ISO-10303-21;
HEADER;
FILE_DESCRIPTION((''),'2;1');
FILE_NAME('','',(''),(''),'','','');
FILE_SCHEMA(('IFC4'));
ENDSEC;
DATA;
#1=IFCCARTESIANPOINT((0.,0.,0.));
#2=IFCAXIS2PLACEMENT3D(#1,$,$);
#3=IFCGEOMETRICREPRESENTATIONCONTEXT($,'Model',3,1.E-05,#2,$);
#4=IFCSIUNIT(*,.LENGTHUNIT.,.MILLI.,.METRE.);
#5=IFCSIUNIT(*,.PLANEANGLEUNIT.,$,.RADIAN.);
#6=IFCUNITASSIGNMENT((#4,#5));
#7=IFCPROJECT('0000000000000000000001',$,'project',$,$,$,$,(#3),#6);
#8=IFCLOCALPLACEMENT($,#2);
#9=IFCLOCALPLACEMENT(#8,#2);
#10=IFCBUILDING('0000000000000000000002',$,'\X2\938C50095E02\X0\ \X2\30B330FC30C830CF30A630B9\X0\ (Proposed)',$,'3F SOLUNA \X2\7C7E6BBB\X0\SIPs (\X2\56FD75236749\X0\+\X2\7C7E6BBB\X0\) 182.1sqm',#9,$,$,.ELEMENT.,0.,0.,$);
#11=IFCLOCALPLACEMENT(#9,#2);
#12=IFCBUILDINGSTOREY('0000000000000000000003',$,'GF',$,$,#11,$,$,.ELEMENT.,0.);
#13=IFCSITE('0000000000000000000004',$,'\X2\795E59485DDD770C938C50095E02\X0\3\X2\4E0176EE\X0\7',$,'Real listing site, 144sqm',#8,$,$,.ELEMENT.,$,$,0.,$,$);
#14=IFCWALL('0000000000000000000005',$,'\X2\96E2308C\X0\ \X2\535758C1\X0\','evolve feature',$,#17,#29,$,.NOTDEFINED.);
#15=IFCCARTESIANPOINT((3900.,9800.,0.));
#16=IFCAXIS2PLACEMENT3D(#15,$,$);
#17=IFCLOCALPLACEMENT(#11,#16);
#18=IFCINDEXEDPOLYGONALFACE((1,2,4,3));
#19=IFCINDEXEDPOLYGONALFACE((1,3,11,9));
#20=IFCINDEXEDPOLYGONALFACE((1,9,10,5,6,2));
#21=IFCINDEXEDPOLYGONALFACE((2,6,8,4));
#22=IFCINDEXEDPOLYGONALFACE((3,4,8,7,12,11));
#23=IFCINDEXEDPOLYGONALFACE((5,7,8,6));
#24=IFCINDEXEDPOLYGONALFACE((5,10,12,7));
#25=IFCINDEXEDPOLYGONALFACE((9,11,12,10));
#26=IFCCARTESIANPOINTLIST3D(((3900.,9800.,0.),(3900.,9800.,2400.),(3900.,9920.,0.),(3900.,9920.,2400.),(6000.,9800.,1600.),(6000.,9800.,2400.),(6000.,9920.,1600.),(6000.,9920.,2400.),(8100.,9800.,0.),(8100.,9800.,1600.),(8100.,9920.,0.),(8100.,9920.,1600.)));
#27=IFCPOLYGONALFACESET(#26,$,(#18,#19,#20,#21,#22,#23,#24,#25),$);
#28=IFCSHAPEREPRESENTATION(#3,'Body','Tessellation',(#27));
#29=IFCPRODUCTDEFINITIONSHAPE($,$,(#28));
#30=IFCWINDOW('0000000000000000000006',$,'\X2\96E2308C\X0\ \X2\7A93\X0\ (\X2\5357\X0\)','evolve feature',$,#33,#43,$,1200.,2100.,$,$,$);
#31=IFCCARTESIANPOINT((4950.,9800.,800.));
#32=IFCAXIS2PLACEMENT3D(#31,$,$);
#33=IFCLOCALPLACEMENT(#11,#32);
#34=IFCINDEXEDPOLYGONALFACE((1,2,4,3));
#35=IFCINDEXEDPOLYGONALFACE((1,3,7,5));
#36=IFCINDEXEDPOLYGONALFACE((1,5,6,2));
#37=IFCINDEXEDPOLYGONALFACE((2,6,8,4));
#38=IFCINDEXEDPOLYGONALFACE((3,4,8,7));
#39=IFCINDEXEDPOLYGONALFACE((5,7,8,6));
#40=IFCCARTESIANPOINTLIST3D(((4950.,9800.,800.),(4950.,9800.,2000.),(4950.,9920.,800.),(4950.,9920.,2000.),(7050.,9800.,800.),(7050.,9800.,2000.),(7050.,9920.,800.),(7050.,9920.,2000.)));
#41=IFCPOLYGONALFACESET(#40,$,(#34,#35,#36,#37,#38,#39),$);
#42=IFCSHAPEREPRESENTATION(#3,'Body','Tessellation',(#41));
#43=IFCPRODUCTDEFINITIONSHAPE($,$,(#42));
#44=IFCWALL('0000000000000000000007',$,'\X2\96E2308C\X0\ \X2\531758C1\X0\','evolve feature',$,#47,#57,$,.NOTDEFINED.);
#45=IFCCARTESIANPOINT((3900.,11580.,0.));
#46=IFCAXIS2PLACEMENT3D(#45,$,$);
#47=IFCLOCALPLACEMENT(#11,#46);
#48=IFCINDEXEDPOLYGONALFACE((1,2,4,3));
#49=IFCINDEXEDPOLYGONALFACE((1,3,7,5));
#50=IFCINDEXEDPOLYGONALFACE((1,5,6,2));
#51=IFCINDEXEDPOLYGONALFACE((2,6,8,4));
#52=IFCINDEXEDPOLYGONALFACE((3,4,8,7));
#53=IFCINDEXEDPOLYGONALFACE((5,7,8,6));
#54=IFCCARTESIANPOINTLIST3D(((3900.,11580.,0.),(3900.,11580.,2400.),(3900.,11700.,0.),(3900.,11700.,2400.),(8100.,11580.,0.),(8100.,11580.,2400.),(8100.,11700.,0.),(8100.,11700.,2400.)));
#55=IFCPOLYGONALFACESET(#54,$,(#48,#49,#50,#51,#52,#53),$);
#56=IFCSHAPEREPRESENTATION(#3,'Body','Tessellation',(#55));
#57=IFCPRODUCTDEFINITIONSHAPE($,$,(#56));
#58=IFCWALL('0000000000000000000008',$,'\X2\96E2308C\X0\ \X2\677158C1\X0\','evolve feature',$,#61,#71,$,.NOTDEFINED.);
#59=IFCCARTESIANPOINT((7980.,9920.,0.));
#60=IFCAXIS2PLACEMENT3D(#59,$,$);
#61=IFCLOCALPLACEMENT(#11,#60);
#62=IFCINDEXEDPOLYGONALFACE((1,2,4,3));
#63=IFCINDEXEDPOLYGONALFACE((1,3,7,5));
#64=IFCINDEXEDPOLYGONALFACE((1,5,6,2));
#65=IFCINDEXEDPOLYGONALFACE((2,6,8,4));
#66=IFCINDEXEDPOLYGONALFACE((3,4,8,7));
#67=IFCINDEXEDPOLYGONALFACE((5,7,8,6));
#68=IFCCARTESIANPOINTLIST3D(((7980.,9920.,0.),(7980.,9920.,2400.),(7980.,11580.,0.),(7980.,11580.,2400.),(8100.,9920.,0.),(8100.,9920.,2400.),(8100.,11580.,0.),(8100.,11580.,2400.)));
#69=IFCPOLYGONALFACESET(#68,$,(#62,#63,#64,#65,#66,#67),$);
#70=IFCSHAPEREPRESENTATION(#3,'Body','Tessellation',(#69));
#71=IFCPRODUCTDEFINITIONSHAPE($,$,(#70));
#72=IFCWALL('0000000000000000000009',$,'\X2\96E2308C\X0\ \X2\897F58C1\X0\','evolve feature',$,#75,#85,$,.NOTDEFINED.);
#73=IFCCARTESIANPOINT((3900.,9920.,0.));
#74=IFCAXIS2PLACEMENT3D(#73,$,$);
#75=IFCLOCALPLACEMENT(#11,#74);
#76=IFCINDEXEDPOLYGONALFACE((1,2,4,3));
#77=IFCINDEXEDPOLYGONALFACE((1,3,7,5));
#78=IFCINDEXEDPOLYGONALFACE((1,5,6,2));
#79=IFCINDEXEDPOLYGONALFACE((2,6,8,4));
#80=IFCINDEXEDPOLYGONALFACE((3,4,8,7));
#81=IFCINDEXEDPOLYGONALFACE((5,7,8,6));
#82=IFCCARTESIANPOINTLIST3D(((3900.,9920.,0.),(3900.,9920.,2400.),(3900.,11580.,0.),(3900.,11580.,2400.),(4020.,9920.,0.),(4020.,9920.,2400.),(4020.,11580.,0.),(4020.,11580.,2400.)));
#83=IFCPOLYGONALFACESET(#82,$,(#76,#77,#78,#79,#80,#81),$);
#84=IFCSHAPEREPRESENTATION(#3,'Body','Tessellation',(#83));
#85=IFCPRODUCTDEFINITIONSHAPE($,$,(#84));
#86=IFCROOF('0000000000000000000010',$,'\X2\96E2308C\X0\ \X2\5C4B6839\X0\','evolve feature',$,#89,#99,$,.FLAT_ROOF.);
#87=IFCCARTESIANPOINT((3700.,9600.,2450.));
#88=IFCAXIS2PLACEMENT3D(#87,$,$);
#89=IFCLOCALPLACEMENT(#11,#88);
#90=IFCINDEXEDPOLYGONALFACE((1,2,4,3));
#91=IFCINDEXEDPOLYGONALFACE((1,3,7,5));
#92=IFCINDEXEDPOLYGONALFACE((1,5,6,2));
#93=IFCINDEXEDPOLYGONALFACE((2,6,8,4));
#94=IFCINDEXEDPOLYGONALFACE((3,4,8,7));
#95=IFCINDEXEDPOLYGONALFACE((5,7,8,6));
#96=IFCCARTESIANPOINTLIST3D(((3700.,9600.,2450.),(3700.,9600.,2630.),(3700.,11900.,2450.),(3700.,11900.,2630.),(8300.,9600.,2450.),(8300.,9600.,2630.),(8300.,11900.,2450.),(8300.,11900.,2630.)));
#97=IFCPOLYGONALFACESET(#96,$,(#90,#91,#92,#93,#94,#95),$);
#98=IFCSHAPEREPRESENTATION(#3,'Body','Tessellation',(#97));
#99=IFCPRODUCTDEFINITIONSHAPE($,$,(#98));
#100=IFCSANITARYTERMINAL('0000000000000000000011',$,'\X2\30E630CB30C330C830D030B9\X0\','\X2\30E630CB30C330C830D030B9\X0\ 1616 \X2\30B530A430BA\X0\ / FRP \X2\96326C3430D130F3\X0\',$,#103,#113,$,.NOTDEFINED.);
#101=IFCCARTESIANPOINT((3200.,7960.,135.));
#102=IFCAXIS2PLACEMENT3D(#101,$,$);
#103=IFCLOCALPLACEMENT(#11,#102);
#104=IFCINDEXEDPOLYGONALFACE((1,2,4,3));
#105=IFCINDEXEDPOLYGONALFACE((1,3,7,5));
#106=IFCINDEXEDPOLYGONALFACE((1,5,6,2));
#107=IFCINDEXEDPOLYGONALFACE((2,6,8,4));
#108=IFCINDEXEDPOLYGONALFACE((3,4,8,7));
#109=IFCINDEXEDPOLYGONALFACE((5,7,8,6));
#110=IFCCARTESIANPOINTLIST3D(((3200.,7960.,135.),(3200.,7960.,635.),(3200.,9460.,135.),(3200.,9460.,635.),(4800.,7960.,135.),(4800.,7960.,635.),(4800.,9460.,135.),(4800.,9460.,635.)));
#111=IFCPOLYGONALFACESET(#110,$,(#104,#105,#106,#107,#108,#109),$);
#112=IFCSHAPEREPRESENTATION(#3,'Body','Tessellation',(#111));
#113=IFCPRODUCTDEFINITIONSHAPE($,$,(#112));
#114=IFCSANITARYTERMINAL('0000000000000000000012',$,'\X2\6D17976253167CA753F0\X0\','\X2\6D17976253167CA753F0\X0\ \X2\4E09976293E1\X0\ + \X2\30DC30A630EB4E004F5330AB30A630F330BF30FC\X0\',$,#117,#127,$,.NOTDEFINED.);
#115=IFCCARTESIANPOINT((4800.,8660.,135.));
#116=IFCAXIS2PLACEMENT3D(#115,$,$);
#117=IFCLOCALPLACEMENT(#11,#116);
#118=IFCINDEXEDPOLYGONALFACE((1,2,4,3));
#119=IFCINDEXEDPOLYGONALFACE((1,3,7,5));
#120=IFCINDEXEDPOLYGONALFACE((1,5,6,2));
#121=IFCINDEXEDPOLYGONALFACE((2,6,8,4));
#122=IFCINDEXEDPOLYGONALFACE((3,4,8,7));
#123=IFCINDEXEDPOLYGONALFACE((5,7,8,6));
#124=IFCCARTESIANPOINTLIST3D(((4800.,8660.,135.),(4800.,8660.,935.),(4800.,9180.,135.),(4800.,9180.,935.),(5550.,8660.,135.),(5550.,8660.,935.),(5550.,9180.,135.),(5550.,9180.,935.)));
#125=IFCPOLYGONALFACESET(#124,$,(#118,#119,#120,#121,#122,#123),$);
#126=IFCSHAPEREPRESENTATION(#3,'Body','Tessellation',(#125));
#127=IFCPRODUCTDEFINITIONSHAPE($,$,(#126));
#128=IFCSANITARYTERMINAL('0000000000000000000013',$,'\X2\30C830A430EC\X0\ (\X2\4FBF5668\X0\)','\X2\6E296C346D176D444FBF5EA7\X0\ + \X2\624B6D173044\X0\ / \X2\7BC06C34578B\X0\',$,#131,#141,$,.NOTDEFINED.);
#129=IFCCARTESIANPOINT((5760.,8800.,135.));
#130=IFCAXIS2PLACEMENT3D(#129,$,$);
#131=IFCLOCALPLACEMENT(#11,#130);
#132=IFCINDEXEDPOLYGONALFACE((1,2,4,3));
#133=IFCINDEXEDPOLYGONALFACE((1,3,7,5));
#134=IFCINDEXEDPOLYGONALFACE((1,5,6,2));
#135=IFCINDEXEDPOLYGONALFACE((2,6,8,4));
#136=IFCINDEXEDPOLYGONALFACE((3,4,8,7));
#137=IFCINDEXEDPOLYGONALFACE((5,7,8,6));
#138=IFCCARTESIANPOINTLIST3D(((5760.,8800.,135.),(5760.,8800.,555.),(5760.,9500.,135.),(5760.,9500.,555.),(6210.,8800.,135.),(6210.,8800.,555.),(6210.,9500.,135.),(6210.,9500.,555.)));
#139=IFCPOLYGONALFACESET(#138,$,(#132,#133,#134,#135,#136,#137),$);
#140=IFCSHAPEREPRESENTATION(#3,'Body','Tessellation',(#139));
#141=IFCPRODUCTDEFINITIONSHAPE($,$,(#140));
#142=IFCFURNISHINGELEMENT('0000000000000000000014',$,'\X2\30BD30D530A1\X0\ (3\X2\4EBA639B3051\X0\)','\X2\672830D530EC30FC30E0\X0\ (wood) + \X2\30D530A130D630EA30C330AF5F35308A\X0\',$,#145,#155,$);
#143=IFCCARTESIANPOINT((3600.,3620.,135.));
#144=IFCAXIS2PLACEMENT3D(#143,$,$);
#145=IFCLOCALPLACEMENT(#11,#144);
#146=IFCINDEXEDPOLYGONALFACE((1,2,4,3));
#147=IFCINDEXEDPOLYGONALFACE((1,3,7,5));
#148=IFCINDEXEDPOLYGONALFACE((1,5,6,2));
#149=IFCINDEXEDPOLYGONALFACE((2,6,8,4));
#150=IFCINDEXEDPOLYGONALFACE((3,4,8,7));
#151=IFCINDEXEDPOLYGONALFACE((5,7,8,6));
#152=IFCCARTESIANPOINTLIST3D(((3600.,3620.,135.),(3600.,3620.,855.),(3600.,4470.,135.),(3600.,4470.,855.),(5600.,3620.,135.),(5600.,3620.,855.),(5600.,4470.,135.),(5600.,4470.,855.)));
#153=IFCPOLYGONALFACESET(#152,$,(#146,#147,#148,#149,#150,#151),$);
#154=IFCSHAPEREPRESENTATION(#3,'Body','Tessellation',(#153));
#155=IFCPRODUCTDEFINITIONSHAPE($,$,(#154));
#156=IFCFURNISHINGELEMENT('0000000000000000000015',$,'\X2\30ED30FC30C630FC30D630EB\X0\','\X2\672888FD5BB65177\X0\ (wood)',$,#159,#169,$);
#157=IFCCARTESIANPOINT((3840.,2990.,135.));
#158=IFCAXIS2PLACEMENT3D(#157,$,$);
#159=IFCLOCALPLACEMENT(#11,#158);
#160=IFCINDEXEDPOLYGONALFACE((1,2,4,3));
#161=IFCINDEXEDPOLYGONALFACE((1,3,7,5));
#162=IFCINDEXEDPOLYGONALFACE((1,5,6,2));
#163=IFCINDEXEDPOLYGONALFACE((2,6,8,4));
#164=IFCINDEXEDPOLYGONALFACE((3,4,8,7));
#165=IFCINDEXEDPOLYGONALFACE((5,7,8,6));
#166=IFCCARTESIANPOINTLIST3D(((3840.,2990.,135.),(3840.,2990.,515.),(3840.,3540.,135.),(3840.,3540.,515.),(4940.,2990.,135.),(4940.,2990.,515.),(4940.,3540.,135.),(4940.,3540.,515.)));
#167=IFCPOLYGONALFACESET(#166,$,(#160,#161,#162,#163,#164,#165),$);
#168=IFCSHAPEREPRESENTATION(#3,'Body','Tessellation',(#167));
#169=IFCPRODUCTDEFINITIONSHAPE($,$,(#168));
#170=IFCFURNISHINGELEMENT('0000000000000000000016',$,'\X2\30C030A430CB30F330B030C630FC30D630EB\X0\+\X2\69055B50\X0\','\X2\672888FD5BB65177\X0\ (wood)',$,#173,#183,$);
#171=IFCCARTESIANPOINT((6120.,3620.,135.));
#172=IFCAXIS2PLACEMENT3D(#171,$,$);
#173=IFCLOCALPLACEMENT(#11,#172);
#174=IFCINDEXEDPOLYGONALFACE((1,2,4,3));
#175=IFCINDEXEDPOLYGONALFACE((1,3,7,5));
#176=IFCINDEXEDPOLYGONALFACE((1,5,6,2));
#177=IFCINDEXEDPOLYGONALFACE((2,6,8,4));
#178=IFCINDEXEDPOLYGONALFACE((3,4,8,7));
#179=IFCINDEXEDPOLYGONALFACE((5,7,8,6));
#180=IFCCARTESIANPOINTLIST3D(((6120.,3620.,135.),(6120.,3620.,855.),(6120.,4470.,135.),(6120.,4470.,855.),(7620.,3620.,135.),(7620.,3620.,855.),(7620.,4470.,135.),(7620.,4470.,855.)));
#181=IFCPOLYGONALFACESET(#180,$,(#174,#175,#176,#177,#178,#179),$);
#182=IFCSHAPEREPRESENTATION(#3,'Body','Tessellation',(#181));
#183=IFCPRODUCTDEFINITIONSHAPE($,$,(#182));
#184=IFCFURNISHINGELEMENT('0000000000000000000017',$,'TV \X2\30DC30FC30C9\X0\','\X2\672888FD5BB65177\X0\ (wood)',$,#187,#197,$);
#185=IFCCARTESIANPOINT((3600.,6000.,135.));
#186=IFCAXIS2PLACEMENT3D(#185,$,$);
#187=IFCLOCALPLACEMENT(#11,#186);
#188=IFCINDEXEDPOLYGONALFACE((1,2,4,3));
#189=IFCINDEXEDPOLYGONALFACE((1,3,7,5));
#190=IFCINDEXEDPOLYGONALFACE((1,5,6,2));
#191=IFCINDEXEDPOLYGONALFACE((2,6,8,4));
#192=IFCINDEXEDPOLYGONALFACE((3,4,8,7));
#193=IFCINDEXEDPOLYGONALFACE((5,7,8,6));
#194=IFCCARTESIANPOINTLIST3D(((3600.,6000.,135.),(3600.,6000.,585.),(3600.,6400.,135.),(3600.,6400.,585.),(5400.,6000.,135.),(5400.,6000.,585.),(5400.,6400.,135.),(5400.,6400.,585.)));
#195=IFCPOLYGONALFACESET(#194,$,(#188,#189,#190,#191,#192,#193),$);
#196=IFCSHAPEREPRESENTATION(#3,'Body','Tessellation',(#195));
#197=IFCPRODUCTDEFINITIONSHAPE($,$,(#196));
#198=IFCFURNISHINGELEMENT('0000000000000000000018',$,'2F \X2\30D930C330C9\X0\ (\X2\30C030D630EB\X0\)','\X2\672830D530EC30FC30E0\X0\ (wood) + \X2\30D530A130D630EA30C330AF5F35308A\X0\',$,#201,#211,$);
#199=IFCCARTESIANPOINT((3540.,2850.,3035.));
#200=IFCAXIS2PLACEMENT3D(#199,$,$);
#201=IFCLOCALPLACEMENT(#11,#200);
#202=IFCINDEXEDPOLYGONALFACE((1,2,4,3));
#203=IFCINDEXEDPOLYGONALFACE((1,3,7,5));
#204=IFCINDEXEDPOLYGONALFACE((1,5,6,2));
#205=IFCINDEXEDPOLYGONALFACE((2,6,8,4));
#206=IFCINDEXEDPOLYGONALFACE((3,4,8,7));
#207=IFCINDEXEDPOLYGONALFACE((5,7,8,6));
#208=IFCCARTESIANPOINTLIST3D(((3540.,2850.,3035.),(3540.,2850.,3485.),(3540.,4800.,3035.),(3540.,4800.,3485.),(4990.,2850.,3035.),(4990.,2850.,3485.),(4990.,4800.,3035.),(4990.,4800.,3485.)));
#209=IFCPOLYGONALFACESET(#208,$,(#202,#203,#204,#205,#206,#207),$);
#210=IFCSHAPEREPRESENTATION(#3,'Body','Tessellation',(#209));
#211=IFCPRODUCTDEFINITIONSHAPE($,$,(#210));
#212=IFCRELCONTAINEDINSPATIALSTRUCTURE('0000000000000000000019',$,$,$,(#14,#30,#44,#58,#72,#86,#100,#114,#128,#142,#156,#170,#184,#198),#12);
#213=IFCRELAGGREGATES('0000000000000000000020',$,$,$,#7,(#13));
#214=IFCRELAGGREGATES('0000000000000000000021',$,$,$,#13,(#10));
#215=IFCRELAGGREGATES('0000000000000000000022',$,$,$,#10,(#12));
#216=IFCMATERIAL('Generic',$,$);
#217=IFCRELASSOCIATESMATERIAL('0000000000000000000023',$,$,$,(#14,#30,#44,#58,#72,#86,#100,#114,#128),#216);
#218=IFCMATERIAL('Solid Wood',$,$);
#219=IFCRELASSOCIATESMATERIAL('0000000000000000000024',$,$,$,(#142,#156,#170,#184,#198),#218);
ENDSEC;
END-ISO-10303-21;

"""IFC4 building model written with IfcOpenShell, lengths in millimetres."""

from ifc_helpers import new_model, si_unit, frame, frame_2d, origin, place, context, project, spatial, rectangle, extrude, material, element, fill, save


model = new_model("IFC4")

# Units and contexts
model_context = context("Model", 3, precision=1e-05, world=origin())
ifc_project = project(units=[si_unit("LENGTHUNIT", "METRE", prefix="MILLI"), si_unit("PLANEANGLEUNIT", "RADIAN")], contexts=[model_context])

# Site, building, storey
site_placement = place(None, origin())
site = spatial("IfcSite", under=ifc_project, at=site_placement, Name="神奈川県鎌倉市3丁目7", ObjectType="Real listing site, 144sqm", CompositionType="ELEMENT", RefElevation=0.0)
building_placement = place(site_placement, origin())
building = spatial("IfcBuilding", under=site, at=building_placement, Name="鎌倉市 コートハウス (Proposed)", ObjectType="3F SOLUNA 籾殻SIPs (国産杉+籾殻) 182.1sqm", CompositionType="ELEMENT", ElevationOfRefHeight=0.0, ElevationOfTerrain=0.0)
storey_placement = place(building_placement, origin())
storey = spatial("IfcBuildingStorey", under=building, at=storey_placement, Name="GF", CompositionType="ELEMENT", Elevation=0.0)

# Shared definitions
ifc_material_1 = material(Name="Generic")

# Shared definitions
ifc_material_2 = material(Name="Solid Wood")

# Wall, opening, window
wall_1_placement = place(storey_placement, frame((3900.0, 9800.0, 0.0)))
wall_1 = element("IfcWall", 1, at=wall_1_placement, inside=storey, material=ifc_material_1, Name="離れ 南壁", Description="evolve feature", PredefinedType="NOTDEFINED", context=model_context, shape_type="SweptSolid", body=[
    extrude(rectangle(XDim=4200.0, YDim=120.0, at=frame_2d((2100.0, 60.0))), frame((3900.0, 9800.0, 0.0)), (0.0, 0.0, 1.0), 2400.0),
])
opening_1_placement = place(storey_placement, frame((4950.0, 9800.0, 800.0)))
opening_1 = element("IfcOpeningElement", 2, at=opening_1_placement, cuts=wall_1, PredefinedType="NOTDEFINED", context=model_context, shape_type="SweptSolid", body=[
    extrude(rectangle(XDim=2100.0, YDim=120.0, at=frame_2d((1050.0, 60.0))), frame((4950.0, 9800.0, 800.0)), (0.0, 0.0, 1.0), 1200.0),
])
window_1_placement = place(storey_placement, frame((4950.0, 9800.0, 800.0)))
window_1 = element("IfcWindow", 3, at=window_1_placement, inside=storey, material=ifc_material_1, Name="離れ 窓 (南)", Description="evolve feature", OverallHeight=1200.0, OverallWidth=2100.0, context=model_context, shape_type="SweptSolid", body=[
    extrude(rectangle(XDim=2100.0, YDim=120.0, at=frame_2d((1050.0, 60.0))), frame((4950.0, 9800.0, 800.0)), (0.0, 0.0, 1.0), 1200.0),
])
fill(opening_1, window_1)

# Walls
wall_2_placement = place(storey_placement, frame((3900.0, 11580.0, 0.0)))
element("IfcWall", 4, at=wall_2_placement, inside=storey, material=ifc_material_1, Name="離れ 北壁", Description="evolve feature", PredefinedType="NOTDEFINED", context=model_context, shape_type="SweptSolid", body=[
    extrude(rectangle(XDim=4200.0, YDim=120.0, at=frame_2d((2100.0, 60.0))), frame((3900.0, 11580.0, 0.0)), (0.0, 0.0, 1.0), 2400.0),
])
wall_3_placement = place(storey_placement, frame((7980.0, 9920.0, 0.0)))
element("IfcWall", 5, at=wall_3_placement, inside=storey, material=ifc_material_1, Name="離れ 東壁", Description="evolve feature", PredefinedType="NOTDEFINED", context=model_context, shape_type="SweptSolid", body=[
    extrude(rectangle(XDim=120.0, YDim=1660.0, at=frame_2d((60.0, 830.0))), frame((7980.0, 9920.0, 0.0)), (0.0, 0.0, 1.0), 2400.0),
])
wall_4_placement = place(storey_placement, frame((3900.0, 9920.0, 0.0)))
element("IfcWall", 6, at=wall_4_placement, inside=storey, material=ifc_material_1, Name="離れ 西壁", Description="evolve feature", PredefinedType="NOTDEFINED", context=model_context, shape_type="SweptSolid", body=[
    extrude(rectangle(XDim=120.0, YDim=1660.0, at=frame_2d((60.0, 830.0))), frame((3900.0, 9920.0, 0.0)), (0.0, 0.0, 1.0), 2400.0),
])

# Roof
roof_placement = place(storey_placement, frame((3700.0, 9600.0, 2450.0)))
element("IfcRoof", 7, at=roof_placement, inside=storey, material=ifc_material_1, Name="離れ 屋根", Description="evolve feature", PredefinedType="FLAT_ROOF", context=model_context, shape_type="SweptSolid", body=[
    extrude(rectangle(XDim=4600.0, YDim=2300.0, at=frame_2d((2300.0, 1150.0))), frame((3700.0, 9600.0, 2450.0)), (0.0, 0.0, 1.0), 180.0),
])

# Sanitary terminals
sanitary_terminal_1_placement = place(storey_placement, frame((3200.0, 7960.0, 135.0)))
element("IfcSanitaryTerminal", 8, at=sanitary_terminal_1_placement, inside=storey, material=ifc_material_1, Name="ユニットバス", Description="ユニットバス 1616 サイズ / FRP 防水パン", PredefinedType="NOTDEFINED", context=model_context, shape_type="SweptSolid", body=[
    extrude(rectangle(XDim=1600.0, YDim=1500.0, at=frame_2d((800.0, 750.0))), frame((3200.0, 7960.0, 135.0)), (0.0, 0.0, 1.0), 500.0),
])
sanitary_terminal_2_placement = place(storey_placement, frame((4800.0, 8660.0, 135.0)))
element("IfcSanitaryTerminal", 9, at=sanitary_terminal_2_placement, inside=storey, material=ifc_material_1, Name="洗面化粧台", Description="洗面化粧台 三面鏡 + ボウル一体カウンター", PredefinedType="NOTDEFINED", context=model_context, shape_type="SweptSolid", body=[
    extrude(rectangle(XDim=750.0, YDim=520.0, at=frame_2d((375.0, 260.0))), frame((4800.0, 8660.0, 135.0)), (0.0, 0.0, 1.0), 800.0),
])
sanitary_terminal_3_placement = place(storey_placement, frame((5760.0, 8800.0, 135.0)))
element("IfcSanitaryTerminal", 10, at=sanitary_terminal_3_placement, inside=storey, material=ifc_material_1, Name="トイレ (便器)", Description="温水洗浄便座 + 手洗い / 節水型", PredefinedType="NOTDEFINED", context=model_context, shape_type="SweptSolid", body=[
    extrude(rectangle(XDim=450.0, YDim=700.0, at=frame_2d((225.0, 350.0))), frame((5760.0, 8800.0, 135.0)), (0.0, 0.0, 1.0), 420.0),
])

# Furnishing elements
furnishing_1_placement = place(storey_placement, frame((3600.0, 3620.0, 135.0)))
element("IfcFurnishingElement", 11, at=furnishing_1_placement, inside=storey, material=ifc_material_2, Name="ソファ (3人掛け)", Description="木フレーム (wood) + ファブリック張り", context=model_context, shape_type="SweptSolid", body=[
    extrude(rectangle(XDim=2000.0, YDim=850.0, at=frame_2d((1000.0, 425.0))), frame((3600.0, 3620.0, 135.0)), (0.0, 0.0, 1.0), 720.0),
])
furnishing_2_placement = place(storey_placement, frame((3840.0, 2990.0, 135.0)))
element("IfcFurnishingElement", 12, at=furnishing_2_placement, inside=storey, material=ifc_material_2, Name="ローテーブル", Description="木製家具 (wood)", context=model_context, shape_type="SweptSolid", body=[
    extrude(rectangle(XDim=1100.0, YDim=550.0, at=frame_2d((550.0, 275.0))), frame((3840.0, 2990.0, 135.0)), (0.0, 0.0, 1.0), 380.0),
])
furnishing_3_placement = place(storey_placement, frame((6120.0, 3620.0, 135.0)))
element("IfcFurnishingElement", 13, at=furnishing_3_placement, inside=storey, material=ifc_material_2, Name="ダイニングテーブル+椅子", Description="木製家具 (wood)", context=model_context, shape_type="SweptSolid", body=[
    extrude(rectangle(XDim=1500.0, YDim=850.0, at=frame_2d((750.0, 425.0))), frame((6120.0, 3620.0, 135.0)), (0.0, 0.0, 1.0), 720.0),
])
furnishing_4_placement = place(storey_placement, frame((3600.0, 6000.0, 135.0)))
element("IfcFurnishingElement", 14, at=furnishing_4_placement, inside=storey, material=ifc_material_2, Name="TV ボード", Description="木製家具 (wood)", context=model_context, shape_type="SweptSolid", body=[
    extrude(rectangle(XDim=1800.0, YDim=400.0, at=frame_2d((900.0, 200.0))), frame((3600.0, 6000.0, 135.0)), (0.0, 0.0, 1.0), 450.0),
])
furnishing_5_placement = place(storey_placement, frame((3540.0, 2850.0, 3035.0)))
element("IfcFurnishingElement", 15, at=furnishing_5_placement, inside=storey, material=ifc_material_2, Name="2F ベッド (ダブル)", Description="木フレーム (wood) + ファブリック張り", context=model_context, shape_type="SweptSolid", body=[
    extrude(rectangle(XDim=1450.0, YDim=1950.0, at=frame_2d((725.0, 975.0))), frame((3540.0, 2850.0, 3035.0)), (0.0, 0.0, 1.0), 450.0),
])

save(model, "model.ifc")
